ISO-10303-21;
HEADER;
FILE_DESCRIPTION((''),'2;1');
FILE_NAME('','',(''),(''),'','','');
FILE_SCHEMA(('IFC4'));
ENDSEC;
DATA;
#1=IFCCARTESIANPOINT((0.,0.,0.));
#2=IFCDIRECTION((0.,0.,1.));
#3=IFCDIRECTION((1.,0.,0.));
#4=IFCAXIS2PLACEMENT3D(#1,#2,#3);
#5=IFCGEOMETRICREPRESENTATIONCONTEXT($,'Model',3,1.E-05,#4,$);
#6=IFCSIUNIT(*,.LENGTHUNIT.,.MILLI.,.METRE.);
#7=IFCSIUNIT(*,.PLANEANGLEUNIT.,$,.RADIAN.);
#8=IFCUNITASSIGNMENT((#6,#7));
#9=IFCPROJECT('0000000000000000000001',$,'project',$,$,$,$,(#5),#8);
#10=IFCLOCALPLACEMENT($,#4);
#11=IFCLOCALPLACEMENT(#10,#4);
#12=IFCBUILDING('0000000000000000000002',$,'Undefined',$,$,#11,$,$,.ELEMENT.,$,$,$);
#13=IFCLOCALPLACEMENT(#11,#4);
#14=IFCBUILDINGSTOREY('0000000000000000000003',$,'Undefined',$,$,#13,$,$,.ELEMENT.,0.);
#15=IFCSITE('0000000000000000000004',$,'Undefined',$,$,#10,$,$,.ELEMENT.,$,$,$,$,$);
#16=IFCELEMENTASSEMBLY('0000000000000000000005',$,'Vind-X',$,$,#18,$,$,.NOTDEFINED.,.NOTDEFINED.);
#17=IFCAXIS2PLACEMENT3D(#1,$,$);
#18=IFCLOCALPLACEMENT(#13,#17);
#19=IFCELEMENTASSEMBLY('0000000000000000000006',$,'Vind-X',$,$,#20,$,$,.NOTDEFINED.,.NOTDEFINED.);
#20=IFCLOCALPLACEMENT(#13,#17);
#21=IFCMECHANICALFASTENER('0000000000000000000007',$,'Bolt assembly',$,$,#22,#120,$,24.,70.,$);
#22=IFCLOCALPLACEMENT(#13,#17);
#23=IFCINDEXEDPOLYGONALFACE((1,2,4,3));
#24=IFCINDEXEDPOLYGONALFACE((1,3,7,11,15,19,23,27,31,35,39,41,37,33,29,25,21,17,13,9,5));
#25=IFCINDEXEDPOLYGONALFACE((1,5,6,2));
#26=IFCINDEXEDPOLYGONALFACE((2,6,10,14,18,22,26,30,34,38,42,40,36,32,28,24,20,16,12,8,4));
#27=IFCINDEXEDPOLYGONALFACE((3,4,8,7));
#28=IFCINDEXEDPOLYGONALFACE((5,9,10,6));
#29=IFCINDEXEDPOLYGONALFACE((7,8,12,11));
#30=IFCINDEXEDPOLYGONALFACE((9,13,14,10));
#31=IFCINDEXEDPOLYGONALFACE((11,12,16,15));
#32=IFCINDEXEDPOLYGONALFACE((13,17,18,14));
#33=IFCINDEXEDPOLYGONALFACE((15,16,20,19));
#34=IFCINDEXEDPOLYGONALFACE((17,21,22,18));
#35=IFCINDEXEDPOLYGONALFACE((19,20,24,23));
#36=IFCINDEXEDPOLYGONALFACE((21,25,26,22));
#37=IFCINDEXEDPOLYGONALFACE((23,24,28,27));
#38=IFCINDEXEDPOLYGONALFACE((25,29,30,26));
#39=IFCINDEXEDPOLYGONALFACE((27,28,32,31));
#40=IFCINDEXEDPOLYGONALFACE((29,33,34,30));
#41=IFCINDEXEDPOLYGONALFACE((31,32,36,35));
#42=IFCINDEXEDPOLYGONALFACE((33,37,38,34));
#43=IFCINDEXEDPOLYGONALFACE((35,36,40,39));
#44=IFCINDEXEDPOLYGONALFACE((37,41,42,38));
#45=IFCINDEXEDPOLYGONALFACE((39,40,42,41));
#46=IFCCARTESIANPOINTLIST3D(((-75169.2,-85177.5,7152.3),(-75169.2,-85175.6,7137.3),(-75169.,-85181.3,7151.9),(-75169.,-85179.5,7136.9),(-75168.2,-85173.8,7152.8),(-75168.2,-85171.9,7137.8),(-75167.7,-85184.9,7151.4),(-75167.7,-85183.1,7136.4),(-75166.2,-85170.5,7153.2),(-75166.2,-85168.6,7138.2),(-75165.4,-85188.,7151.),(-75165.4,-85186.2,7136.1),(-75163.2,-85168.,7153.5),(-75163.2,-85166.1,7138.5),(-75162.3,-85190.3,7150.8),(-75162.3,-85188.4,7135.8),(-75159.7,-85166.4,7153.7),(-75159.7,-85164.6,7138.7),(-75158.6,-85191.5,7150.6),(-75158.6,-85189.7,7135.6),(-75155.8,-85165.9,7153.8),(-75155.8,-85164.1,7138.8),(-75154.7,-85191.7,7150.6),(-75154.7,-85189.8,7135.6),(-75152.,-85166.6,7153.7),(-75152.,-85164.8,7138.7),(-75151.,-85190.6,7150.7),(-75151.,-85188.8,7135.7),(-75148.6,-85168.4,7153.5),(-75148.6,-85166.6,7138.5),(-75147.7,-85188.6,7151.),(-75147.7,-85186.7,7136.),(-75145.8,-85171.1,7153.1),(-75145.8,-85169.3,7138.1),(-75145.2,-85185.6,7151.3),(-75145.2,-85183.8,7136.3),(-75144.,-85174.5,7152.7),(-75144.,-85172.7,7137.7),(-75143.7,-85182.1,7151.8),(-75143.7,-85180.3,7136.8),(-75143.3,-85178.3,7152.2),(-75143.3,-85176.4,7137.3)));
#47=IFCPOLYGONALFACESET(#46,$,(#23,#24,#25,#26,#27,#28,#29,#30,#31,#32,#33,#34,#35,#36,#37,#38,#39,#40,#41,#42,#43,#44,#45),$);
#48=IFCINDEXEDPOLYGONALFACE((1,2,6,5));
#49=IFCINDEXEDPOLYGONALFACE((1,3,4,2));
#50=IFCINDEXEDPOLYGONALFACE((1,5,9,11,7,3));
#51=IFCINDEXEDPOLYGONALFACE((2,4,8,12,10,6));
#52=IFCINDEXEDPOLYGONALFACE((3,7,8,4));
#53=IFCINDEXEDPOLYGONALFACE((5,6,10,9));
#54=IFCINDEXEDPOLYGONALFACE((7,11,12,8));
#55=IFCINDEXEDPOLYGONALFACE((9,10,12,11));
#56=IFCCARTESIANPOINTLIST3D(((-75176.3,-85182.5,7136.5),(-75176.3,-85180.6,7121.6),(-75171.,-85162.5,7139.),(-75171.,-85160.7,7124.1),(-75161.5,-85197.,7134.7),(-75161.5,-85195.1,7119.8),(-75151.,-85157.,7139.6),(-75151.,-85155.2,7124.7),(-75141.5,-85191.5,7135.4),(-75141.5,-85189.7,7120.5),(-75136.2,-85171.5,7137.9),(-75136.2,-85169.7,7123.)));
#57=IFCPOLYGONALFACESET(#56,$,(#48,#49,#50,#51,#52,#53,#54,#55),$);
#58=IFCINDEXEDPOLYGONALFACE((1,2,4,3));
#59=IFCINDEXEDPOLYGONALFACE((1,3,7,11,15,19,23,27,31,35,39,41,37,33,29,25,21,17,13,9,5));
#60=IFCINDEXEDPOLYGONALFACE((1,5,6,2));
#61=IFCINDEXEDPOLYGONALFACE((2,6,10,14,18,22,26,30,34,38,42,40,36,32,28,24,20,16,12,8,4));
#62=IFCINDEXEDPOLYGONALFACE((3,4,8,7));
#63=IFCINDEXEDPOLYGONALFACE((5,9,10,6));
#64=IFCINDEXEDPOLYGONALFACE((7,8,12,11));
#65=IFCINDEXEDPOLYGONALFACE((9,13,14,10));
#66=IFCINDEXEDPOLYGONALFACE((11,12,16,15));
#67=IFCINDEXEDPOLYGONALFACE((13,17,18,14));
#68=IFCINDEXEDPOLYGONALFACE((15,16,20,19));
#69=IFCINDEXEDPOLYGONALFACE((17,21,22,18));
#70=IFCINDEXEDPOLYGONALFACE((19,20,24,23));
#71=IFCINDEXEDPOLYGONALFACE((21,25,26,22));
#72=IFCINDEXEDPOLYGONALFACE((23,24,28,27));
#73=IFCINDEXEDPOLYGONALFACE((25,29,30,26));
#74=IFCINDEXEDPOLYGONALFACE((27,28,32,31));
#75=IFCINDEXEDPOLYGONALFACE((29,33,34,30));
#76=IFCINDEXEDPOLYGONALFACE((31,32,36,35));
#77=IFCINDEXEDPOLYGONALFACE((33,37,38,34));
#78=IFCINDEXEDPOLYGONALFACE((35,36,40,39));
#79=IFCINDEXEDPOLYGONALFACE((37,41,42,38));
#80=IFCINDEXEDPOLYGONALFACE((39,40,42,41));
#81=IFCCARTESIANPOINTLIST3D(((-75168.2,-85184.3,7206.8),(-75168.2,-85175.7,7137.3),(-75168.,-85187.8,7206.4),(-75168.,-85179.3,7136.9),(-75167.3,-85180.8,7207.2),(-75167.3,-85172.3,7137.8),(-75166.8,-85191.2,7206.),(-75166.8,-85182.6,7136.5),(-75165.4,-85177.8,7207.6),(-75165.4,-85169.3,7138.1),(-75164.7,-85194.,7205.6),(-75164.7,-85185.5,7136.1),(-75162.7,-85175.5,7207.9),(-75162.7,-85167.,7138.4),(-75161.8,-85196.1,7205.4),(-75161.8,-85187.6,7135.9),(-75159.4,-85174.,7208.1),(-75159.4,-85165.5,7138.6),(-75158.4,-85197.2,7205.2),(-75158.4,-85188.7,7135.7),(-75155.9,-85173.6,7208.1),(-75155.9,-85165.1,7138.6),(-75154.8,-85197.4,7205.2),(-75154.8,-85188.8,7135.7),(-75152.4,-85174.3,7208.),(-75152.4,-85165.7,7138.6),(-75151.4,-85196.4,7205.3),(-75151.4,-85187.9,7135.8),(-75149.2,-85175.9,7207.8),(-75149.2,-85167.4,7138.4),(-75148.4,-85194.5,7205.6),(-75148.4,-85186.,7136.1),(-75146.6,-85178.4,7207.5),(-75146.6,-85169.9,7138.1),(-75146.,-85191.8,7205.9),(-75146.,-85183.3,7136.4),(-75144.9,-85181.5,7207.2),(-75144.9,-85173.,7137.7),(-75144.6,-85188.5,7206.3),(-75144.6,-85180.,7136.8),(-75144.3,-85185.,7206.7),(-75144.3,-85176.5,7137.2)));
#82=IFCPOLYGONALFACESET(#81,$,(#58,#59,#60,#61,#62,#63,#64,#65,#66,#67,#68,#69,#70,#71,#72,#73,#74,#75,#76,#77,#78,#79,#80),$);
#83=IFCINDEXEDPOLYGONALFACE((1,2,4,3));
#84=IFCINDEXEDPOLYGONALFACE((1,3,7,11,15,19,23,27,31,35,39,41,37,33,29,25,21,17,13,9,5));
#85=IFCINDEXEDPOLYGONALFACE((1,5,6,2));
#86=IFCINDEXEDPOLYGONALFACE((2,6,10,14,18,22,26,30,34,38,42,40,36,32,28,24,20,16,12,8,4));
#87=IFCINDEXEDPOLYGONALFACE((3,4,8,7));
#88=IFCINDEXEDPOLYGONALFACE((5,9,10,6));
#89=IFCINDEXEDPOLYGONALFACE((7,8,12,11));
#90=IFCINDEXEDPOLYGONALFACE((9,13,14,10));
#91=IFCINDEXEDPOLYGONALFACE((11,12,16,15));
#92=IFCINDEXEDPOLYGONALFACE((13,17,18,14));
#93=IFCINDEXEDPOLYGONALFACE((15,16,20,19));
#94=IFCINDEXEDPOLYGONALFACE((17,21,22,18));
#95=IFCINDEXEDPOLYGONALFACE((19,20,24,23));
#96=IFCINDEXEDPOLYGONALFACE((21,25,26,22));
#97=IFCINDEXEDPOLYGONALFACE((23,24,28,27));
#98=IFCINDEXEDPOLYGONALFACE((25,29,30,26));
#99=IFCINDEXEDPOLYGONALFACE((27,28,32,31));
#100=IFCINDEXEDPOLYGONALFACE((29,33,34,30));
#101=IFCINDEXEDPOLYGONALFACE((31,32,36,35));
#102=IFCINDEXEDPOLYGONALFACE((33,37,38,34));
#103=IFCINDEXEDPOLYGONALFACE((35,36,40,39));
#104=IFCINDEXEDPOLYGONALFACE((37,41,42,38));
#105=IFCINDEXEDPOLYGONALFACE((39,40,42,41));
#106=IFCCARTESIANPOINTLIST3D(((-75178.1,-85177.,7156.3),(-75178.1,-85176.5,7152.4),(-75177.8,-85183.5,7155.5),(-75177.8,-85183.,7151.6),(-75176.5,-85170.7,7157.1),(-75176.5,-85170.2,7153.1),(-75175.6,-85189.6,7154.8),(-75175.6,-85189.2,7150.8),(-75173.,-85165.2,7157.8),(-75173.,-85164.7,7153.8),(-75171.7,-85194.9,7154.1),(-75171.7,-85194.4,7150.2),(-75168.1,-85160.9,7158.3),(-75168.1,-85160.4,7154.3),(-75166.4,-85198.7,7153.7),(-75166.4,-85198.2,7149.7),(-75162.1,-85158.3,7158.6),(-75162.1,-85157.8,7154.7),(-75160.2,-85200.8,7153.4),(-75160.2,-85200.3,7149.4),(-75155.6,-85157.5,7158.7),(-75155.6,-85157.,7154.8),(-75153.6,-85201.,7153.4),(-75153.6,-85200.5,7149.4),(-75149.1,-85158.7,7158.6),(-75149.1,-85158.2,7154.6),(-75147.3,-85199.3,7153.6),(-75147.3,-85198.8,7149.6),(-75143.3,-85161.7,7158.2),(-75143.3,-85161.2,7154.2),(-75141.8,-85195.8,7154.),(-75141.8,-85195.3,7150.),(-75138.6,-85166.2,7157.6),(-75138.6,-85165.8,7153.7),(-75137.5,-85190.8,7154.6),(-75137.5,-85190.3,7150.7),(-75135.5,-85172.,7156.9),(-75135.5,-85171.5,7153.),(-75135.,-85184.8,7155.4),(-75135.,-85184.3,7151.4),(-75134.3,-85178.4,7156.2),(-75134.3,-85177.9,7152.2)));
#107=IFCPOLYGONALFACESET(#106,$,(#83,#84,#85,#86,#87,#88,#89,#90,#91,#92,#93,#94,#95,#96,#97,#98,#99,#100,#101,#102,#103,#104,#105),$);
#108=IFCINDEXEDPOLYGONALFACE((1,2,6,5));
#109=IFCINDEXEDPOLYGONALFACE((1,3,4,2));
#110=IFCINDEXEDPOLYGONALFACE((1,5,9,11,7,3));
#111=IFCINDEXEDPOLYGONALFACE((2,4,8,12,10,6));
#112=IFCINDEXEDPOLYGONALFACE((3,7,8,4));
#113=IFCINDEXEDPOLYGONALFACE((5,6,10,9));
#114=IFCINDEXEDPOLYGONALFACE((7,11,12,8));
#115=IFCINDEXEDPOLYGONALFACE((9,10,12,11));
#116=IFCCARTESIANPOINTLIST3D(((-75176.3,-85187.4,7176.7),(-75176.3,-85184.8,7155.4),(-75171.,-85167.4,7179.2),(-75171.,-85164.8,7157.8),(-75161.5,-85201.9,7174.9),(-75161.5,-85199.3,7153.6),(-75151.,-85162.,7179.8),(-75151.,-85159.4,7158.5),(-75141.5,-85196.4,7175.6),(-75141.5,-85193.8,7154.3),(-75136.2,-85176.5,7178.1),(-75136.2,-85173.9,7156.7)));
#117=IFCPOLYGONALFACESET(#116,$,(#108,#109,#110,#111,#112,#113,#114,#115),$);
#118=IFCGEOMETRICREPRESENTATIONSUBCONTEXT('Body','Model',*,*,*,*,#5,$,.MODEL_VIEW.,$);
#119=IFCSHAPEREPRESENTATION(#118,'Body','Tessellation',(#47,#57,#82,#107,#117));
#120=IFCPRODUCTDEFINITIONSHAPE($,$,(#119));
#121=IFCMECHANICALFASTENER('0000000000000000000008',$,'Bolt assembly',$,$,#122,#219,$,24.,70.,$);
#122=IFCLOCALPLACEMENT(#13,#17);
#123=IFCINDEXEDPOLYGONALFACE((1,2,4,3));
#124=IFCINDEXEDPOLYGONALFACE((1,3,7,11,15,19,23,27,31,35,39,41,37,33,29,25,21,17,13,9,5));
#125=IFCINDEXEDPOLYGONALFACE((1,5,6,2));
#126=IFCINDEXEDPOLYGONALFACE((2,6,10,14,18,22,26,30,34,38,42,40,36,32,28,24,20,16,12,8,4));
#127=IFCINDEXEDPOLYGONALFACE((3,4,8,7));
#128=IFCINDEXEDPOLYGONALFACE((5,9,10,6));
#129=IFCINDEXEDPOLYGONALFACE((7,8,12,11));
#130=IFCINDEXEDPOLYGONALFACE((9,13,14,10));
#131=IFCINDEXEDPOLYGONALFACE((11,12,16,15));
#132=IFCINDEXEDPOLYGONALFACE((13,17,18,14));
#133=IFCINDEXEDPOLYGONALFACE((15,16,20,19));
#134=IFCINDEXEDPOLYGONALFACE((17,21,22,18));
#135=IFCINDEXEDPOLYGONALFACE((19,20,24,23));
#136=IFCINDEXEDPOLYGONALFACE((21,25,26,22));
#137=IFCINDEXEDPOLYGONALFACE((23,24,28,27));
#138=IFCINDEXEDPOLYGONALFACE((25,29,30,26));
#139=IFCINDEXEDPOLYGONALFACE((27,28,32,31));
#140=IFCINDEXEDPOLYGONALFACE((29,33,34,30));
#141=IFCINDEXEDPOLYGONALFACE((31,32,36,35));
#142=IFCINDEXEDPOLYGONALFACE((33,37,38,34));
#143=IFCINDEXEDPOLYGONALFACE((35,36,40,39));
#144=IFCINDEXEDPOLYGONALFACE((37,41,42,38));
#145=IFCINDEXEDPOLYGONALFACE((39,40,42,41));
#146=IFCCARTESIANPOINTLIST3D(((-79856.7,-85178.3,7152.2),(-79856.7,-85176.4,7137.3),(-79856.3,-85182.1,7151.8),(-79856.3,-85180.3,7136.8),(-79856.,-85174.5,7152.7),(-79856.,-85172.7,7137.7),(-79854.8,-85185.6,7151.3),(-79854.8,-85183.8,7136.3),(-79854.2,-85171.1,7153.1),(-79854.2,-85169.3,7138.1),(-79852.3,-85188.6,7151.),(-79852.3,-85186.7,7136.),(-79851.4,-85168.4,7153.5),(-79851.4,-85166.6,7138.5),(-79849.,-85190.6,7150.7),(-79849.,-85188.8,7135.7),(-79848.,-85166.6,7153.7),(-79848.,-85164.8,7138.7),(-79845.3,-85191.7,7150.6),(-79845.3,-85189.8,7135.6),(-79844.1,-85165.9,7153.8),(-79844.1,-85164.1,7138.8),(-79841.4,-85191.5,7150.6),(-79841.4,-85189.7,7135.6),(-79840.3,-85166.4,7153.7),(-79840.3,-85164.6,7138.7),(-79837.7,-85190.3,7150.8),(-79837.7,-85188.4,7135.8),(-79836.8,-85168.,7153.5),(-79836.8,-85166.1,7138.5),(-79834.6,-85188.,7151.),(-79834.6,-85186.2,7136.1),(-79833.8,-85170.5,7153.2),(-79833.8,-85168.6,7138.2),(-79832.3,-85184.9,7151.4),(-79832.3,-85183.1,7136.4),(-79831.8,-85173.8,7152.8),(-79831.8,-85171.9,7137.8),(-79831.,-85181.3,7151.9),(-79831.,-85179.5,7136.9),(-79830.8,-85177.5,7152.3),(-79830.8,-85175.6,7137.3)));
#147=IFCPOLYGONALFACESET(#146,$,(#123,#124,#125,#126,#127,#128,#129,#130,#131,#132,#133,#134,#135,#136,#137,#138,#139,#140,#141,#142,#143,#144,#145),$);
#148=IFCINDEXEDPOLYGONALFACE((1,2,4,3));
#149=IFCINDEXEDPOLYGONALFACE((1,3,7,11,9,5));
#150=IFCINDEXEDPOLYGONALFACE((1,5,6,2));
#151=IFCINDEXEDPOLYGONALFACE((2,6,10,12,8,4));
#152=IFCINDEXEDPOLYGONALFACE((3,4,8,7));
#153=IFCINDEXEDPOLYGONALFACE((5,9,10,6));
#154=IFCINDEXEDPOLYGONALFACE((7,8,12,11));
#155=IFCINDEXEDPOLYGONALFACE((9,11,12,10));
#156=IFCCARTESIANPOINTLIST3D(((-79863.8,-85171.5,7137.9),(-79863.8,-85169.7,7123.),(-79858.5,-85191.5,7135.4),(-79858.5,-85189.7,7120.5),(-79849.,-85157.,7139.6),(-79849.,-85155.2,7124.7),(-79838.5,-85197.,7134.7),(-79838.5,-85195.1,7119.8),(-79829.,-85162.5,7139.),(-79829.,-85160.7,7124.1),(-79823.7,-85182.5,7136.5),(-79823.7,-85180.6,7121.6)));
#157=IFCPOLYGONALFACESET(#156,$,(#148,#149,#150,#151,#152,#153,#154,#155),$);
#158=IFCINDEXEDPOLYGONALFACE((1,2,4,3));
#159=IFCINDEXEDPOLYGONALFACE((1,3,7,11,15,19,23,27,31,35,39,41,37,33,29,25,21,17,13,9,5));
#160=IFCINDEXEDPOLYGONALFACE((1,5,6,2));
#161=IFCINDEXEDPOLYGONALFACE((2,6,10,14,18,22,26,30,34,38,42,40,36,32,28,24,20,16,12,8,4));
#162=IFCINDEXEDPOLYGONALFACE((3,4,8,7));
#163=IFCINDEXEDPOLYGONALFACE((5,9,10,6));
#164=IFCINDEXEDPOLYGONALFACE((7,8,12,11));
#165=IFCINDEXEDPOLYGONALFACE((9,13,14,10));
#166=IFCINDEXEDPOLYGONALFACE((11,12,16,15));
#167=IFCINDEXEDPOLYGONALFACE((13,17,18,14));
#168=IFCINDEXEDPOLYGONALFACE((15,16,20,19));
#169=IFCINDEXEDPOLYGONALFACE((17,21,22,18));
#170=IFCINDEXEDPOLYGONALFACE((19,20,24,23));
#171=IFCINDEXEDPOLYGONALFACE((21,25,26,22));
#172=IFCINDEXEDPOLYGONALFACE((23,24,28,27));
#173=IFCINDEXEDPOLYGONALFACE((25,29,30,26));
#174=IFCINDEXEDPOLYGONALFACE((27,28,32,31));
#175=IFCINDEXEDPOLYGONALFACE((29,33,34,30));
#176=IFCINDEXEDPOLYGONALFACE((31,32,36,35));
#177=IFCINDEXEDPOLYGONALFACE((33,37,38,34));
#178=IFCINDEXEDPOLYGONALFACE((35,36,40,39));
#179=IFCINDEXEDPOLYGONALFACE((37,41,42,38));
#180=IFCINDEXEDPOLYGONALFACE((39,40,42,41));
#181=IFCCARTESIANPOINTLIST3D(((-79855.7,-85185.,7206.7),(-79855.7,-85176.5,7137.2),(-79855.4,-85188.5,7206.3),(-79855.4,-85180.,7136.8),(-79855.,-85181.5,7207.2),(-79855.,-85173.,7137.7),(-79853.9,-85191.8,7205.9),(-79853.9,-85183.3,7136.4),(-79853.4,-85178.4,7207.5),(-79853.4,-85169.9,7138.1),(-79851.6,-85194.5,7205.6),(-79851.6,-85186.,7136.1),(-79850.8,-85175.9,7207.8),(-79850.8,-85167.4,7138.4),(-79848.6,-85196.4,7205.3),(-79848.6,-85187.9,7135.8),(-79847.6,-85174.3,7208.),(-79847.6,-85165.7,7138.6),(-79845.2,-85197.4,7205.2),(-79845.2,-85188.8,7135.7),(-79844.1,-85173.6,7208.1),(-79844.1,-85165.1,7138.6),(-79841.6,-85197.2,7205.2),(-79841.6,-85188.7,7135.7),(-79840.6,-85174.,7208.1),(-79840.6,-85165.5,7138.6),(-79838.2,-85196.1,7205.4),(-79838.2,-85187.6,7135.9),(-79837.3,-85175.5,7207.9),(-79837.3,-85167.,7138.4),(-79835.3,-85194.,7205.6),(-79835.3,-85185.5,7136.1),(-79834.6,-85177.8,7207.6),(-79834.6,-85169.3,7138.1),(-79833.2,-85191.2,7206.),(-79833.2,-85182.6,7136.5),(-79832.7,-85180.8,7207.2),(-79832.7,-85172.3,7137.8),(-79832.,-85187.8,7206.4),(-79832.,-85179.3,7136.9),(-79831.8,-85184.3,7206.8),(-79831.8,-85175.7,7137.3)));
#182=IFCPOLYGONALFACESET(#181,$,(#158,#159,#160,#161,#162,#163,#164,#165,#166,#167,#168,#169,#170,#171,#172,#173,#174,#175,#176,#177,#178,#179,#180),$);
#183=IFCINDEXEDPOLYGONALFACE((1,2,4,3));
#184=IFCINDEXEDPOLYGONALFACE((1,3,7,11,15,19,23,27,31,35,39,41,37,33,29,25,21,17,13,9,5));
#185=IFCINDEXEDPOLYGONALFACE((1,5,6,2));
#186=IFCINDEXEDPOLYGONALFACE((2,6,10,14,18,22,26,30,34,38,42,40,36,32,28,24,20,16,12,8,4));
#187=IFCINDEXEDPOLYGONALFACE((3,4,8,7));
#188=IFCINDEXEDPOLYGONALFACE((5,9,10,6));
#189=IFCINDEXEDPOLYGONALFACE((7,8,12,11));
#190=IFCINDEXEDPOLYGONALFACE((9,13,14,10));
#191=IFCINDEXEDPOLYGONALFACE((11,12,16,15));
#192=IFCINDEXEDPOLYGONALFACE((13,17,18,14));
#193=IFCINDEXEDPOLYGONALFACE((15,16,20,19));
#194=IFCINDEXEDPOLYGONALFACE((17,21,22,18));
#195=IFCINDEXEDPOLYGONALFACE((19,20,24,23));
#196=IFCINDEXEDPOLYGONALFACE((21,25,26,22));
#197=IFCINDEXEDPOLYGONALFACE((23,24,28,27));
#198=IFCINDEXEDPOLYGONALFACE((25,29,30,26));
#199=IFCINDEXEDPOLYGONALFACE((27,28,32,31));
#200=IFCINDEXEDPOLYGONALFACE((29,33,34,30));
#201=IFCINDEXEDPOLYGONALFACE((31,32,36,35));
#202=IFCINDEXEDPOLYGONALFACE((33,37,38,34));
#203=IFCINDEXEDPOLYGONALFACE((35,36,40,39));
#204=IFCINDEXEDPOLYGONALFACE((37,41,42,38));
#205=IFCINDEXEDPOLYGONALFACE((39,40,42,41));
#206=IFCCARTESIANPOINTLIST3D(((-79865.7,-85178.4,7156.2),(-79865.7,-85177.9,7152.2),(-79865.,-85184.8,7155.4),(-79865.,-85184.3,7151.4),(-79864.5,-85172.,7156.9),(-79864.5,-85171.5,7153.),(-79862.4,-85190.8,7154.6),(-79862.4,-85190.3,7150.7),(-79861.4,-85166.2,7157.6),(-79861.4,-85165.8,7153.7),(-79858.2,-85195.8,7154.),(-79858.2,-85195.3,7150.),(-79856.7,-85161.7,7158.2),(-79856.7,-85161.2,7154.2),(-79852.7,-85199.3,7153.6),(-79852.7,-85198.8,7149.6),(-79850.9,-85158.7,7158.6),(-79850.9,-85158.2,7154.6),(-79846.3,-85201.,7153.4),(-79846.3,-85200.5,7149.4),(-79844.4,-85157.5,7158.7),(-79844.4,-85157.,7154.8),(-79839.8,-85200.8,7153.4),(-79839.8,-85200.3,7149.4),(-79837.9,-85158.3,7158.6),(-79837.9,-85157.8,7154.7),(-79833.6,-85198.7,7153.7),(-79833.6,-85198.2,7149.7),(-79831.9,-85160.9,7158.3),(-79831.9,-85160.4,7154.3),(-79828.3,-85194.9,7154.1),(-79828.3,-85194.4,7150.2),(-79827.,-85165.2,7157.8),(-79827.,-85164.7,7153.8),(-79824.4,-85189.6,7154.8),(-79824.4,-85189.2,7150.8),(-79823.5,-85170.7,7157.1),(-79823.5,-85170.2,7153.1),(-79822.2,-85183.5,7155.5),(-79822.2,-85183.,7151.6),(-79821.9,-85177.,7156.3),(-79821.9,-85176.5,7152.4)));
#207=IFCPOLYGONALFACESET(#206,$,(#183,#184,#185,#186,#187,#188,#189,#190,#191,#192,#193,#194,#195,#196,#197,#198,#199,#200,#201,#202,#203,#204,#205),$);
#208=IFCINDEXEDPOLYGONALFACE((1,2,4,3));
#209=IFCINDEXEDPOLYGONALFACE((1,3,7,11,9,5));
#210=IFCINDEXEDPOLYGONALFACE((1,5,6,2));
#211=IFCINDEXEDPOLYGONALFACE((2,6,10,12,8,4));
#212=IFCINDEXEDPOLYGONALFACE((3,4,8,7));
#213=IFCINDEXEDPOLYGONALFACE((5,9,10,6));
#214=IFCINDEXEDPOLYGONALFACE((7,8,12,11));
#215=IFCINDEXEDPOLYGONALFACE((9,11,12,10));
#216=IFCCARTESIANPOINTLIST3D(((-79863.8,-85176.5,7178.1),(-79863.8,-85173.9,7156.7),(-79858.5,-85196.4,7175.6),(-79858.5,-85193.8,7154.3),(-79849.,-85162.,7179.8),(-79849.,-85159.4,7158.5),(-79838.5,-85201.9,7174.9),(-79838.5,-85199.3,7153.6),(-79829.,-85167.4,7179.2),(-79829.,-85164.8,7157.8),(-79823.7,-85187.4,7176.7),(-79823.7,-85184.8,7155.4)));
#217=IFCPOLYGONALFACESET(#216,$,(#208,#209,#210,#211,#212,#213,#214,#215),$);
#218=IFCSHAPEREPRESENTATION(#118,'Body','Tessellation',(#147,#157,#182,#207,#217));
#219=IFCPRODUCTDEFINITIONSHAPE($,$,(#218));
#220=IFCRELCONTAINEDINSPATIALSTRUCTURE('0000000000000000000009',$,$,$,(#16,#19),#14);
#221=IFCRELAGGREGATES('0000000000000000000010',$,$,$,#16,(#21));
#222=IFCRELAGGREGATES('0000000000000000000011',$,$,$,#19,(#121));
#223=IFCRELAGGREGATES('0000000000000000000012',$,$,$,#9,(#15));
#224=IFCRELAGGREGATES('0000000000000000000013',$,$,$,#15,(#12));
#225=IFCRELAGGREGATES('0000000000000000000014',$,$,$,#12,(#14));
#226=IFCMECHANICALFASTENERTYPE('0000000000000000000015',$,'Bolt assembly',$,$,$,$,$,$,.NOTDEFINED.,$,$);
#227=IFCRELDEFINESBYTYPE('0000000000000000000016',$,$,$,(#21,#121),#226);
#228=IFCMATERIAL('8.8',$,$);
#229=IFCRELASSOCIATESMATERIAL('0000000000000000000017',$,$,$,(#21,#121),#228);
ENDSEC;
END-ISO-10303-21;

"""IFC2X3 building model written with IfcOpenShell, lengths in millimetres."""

from ifc_helpers import new_model, si_unit, frame, origin_with_axes, origin_2d_with_axis, place, context, subcontext, project, spatial, polyline, circle, outline, extrude, source, transform, mapped, material, type_object, element, aggregate, save


model = new_model("IFC2X3")

# Units and contexts
model_context = context("Model", 3, precision=1e-05, world=origin_with_axes())
body_context = subcontext(model_context, "Body", "Model", "MODEL_VIEW")
ifc_project = project(units=[si_unit("LENGTHUNIT", "METRE", prefix="MILLI"), si_unit("PLANEANGLEUNIT", "RADIAN")], contexts=[model_context])

# Site, building, storey
site_placement = place(None, origin_with_axes())
site = spatial("IfcSite", under=ifc_project, at=site_placement, Name="Undefined", CompositionType="ELEMENT")
building_placement = place(site_placement, origin_with_axes())
building = spatial("IfcBuilding", under=site, at=building_placement, Name="Undefined", CompositionType="ELEMENT")
storey_placement = place(building_placement, origin_with_axes())
storey = spatial("IfcBuildingStorey", under=building, at=storey_placement, Name="Undefined", CompositionType="ELEMENT", Elevation=0.0)

# Element assembly
assembly_1_placement = place(storey_placement, origin_with_axes())
assembly_1 = element("IfcElementAssembly", 1, at=assembly_1_placement, inside=storey, Name="Vind-X", AssemblyPlace="NOTDEFINED", PredefinedType="NOTDEFINED")

# Element assembly
assembly_2_placement = place(storey_placement, origin_with_axes())
assembly_2 = element("IfcElementAssembly", 2, at=assembly_2_placement, inside=storey, Name="Vind-X", AssemblyPlace="NOTDEFINED", PredefinedType="NOTDEFINED")

# Mechanical fasteners
ifc_material_1 = material(Name="8.8")
mechanical_fastener_type = type_object("IfcMechanicalFastenerType", Name="Bolt assembly")
shared_shape_1 = source(origin_with_axes(), body_context, "Body", "SweptSolid", [
    extrude(circle(Radius=13.0, at=origin_2d_with_axis()), frame((0.0, 0.0, 0.0), z_axis=(0.0, 1.0, 0.0), x_axis=(1.0, 0.0, 0.0)), (0.0, 0.0, 1.0), 15.1),
    extrude(outline(polyline([(18.0, -10.4), (18.0, 10.4), (0.0, 20.8), (-18.0, 10.4), (-18.0, -10.4), (0.0, -20.8), (18.0, -10.4)])), frame((0.0, -15.0, 0.0), z_axis=(0.0, 1.0, 0.0), x_axis=(1.0, 0.0, 0.0)), (0.0, 0.0, 1.0), 15.0),
    extrude(circle(Radius=12.0, at=origin_2d_with_axis()), frame((0.0, 0.0, 0.0), z_axis=(0.0, 1.0, 0.0), x_axis=(1.0, 0.0, 0.0)), (0.0, 0.0, 1.0), 70.0),
    extrude(circle(Radius=22.0, at=origin_2d_with_axis()), frame((0.0, 15.0, 0.0), z_axis=(0.0, 1.0, 0.0), x_axis=(1.0, 0.0, 0.0)), (0.0, 0.0, 1.0), 4.0),
    extrude(outline(polyline([(18.0, -10.4), (18.0, 10.4), (0.0, 20.8), (-18.0, 10.4), (-18.0, -10.4), (0.0, -20.8), (18.0, -10.4)])), frame((0.0, 19.0, 0.0), z_axis=(0.0, 1.0, 0.0), x_axis=(1.0, 0.0, 0.0)), (0.0, 0.0, 1.0), 21.5),
])
mechanical_fastener_1_placement = place(assembly_1_placement, frame((-75156.3, -85177.0, 7137.2), z_axis=(-0.711592, 0.697356, 0.085625), x_axis=(-0.702593, -0.706288, -0.086721)))
mechanical_fastener_1 = element("IfcMechanicalFastener", 3, at=mechanical_fastener_1_placement, type_object=mechanical_fastener_type, material=ifc_material_1, Name="Bolt assembly", NominalDiameter=24.0, NominalLength=70.0, context=body_context, shape_type="MappedRepresentation", body=[
    mapped(shared_shape_1, transform((0.0, 0.0, 0.0))),
])
aggregate(assembly_1, [mechanical_fastener_1])
mechanical_fastener_2_placement = place(assembly_2_placement, frame((-79843.7, -85177.0, 7137.2), z_axis=(-0.711592, -0.697356, -0.085625), x_axis=(0.702593, -0.706288, -0.086721)))
mechanical_fastener_2 = element("IfcMechanicalFastener", 4, at=mechanical_fastener_2_placement, type_object=mechanical_fastener_type, material=ifc_material_1, Name="Bolt assembly", NominalDiameter=24.0, NominalLength=70.0, context=body_context, shape_type="MappedRepresentation", body=[
    mapped(shared_shape_1, transform((0.0, 0.0, 0.0))),
])
aggregate(assembly_2, [mechanical_fastener_2])

save(model, "model.ifc")
